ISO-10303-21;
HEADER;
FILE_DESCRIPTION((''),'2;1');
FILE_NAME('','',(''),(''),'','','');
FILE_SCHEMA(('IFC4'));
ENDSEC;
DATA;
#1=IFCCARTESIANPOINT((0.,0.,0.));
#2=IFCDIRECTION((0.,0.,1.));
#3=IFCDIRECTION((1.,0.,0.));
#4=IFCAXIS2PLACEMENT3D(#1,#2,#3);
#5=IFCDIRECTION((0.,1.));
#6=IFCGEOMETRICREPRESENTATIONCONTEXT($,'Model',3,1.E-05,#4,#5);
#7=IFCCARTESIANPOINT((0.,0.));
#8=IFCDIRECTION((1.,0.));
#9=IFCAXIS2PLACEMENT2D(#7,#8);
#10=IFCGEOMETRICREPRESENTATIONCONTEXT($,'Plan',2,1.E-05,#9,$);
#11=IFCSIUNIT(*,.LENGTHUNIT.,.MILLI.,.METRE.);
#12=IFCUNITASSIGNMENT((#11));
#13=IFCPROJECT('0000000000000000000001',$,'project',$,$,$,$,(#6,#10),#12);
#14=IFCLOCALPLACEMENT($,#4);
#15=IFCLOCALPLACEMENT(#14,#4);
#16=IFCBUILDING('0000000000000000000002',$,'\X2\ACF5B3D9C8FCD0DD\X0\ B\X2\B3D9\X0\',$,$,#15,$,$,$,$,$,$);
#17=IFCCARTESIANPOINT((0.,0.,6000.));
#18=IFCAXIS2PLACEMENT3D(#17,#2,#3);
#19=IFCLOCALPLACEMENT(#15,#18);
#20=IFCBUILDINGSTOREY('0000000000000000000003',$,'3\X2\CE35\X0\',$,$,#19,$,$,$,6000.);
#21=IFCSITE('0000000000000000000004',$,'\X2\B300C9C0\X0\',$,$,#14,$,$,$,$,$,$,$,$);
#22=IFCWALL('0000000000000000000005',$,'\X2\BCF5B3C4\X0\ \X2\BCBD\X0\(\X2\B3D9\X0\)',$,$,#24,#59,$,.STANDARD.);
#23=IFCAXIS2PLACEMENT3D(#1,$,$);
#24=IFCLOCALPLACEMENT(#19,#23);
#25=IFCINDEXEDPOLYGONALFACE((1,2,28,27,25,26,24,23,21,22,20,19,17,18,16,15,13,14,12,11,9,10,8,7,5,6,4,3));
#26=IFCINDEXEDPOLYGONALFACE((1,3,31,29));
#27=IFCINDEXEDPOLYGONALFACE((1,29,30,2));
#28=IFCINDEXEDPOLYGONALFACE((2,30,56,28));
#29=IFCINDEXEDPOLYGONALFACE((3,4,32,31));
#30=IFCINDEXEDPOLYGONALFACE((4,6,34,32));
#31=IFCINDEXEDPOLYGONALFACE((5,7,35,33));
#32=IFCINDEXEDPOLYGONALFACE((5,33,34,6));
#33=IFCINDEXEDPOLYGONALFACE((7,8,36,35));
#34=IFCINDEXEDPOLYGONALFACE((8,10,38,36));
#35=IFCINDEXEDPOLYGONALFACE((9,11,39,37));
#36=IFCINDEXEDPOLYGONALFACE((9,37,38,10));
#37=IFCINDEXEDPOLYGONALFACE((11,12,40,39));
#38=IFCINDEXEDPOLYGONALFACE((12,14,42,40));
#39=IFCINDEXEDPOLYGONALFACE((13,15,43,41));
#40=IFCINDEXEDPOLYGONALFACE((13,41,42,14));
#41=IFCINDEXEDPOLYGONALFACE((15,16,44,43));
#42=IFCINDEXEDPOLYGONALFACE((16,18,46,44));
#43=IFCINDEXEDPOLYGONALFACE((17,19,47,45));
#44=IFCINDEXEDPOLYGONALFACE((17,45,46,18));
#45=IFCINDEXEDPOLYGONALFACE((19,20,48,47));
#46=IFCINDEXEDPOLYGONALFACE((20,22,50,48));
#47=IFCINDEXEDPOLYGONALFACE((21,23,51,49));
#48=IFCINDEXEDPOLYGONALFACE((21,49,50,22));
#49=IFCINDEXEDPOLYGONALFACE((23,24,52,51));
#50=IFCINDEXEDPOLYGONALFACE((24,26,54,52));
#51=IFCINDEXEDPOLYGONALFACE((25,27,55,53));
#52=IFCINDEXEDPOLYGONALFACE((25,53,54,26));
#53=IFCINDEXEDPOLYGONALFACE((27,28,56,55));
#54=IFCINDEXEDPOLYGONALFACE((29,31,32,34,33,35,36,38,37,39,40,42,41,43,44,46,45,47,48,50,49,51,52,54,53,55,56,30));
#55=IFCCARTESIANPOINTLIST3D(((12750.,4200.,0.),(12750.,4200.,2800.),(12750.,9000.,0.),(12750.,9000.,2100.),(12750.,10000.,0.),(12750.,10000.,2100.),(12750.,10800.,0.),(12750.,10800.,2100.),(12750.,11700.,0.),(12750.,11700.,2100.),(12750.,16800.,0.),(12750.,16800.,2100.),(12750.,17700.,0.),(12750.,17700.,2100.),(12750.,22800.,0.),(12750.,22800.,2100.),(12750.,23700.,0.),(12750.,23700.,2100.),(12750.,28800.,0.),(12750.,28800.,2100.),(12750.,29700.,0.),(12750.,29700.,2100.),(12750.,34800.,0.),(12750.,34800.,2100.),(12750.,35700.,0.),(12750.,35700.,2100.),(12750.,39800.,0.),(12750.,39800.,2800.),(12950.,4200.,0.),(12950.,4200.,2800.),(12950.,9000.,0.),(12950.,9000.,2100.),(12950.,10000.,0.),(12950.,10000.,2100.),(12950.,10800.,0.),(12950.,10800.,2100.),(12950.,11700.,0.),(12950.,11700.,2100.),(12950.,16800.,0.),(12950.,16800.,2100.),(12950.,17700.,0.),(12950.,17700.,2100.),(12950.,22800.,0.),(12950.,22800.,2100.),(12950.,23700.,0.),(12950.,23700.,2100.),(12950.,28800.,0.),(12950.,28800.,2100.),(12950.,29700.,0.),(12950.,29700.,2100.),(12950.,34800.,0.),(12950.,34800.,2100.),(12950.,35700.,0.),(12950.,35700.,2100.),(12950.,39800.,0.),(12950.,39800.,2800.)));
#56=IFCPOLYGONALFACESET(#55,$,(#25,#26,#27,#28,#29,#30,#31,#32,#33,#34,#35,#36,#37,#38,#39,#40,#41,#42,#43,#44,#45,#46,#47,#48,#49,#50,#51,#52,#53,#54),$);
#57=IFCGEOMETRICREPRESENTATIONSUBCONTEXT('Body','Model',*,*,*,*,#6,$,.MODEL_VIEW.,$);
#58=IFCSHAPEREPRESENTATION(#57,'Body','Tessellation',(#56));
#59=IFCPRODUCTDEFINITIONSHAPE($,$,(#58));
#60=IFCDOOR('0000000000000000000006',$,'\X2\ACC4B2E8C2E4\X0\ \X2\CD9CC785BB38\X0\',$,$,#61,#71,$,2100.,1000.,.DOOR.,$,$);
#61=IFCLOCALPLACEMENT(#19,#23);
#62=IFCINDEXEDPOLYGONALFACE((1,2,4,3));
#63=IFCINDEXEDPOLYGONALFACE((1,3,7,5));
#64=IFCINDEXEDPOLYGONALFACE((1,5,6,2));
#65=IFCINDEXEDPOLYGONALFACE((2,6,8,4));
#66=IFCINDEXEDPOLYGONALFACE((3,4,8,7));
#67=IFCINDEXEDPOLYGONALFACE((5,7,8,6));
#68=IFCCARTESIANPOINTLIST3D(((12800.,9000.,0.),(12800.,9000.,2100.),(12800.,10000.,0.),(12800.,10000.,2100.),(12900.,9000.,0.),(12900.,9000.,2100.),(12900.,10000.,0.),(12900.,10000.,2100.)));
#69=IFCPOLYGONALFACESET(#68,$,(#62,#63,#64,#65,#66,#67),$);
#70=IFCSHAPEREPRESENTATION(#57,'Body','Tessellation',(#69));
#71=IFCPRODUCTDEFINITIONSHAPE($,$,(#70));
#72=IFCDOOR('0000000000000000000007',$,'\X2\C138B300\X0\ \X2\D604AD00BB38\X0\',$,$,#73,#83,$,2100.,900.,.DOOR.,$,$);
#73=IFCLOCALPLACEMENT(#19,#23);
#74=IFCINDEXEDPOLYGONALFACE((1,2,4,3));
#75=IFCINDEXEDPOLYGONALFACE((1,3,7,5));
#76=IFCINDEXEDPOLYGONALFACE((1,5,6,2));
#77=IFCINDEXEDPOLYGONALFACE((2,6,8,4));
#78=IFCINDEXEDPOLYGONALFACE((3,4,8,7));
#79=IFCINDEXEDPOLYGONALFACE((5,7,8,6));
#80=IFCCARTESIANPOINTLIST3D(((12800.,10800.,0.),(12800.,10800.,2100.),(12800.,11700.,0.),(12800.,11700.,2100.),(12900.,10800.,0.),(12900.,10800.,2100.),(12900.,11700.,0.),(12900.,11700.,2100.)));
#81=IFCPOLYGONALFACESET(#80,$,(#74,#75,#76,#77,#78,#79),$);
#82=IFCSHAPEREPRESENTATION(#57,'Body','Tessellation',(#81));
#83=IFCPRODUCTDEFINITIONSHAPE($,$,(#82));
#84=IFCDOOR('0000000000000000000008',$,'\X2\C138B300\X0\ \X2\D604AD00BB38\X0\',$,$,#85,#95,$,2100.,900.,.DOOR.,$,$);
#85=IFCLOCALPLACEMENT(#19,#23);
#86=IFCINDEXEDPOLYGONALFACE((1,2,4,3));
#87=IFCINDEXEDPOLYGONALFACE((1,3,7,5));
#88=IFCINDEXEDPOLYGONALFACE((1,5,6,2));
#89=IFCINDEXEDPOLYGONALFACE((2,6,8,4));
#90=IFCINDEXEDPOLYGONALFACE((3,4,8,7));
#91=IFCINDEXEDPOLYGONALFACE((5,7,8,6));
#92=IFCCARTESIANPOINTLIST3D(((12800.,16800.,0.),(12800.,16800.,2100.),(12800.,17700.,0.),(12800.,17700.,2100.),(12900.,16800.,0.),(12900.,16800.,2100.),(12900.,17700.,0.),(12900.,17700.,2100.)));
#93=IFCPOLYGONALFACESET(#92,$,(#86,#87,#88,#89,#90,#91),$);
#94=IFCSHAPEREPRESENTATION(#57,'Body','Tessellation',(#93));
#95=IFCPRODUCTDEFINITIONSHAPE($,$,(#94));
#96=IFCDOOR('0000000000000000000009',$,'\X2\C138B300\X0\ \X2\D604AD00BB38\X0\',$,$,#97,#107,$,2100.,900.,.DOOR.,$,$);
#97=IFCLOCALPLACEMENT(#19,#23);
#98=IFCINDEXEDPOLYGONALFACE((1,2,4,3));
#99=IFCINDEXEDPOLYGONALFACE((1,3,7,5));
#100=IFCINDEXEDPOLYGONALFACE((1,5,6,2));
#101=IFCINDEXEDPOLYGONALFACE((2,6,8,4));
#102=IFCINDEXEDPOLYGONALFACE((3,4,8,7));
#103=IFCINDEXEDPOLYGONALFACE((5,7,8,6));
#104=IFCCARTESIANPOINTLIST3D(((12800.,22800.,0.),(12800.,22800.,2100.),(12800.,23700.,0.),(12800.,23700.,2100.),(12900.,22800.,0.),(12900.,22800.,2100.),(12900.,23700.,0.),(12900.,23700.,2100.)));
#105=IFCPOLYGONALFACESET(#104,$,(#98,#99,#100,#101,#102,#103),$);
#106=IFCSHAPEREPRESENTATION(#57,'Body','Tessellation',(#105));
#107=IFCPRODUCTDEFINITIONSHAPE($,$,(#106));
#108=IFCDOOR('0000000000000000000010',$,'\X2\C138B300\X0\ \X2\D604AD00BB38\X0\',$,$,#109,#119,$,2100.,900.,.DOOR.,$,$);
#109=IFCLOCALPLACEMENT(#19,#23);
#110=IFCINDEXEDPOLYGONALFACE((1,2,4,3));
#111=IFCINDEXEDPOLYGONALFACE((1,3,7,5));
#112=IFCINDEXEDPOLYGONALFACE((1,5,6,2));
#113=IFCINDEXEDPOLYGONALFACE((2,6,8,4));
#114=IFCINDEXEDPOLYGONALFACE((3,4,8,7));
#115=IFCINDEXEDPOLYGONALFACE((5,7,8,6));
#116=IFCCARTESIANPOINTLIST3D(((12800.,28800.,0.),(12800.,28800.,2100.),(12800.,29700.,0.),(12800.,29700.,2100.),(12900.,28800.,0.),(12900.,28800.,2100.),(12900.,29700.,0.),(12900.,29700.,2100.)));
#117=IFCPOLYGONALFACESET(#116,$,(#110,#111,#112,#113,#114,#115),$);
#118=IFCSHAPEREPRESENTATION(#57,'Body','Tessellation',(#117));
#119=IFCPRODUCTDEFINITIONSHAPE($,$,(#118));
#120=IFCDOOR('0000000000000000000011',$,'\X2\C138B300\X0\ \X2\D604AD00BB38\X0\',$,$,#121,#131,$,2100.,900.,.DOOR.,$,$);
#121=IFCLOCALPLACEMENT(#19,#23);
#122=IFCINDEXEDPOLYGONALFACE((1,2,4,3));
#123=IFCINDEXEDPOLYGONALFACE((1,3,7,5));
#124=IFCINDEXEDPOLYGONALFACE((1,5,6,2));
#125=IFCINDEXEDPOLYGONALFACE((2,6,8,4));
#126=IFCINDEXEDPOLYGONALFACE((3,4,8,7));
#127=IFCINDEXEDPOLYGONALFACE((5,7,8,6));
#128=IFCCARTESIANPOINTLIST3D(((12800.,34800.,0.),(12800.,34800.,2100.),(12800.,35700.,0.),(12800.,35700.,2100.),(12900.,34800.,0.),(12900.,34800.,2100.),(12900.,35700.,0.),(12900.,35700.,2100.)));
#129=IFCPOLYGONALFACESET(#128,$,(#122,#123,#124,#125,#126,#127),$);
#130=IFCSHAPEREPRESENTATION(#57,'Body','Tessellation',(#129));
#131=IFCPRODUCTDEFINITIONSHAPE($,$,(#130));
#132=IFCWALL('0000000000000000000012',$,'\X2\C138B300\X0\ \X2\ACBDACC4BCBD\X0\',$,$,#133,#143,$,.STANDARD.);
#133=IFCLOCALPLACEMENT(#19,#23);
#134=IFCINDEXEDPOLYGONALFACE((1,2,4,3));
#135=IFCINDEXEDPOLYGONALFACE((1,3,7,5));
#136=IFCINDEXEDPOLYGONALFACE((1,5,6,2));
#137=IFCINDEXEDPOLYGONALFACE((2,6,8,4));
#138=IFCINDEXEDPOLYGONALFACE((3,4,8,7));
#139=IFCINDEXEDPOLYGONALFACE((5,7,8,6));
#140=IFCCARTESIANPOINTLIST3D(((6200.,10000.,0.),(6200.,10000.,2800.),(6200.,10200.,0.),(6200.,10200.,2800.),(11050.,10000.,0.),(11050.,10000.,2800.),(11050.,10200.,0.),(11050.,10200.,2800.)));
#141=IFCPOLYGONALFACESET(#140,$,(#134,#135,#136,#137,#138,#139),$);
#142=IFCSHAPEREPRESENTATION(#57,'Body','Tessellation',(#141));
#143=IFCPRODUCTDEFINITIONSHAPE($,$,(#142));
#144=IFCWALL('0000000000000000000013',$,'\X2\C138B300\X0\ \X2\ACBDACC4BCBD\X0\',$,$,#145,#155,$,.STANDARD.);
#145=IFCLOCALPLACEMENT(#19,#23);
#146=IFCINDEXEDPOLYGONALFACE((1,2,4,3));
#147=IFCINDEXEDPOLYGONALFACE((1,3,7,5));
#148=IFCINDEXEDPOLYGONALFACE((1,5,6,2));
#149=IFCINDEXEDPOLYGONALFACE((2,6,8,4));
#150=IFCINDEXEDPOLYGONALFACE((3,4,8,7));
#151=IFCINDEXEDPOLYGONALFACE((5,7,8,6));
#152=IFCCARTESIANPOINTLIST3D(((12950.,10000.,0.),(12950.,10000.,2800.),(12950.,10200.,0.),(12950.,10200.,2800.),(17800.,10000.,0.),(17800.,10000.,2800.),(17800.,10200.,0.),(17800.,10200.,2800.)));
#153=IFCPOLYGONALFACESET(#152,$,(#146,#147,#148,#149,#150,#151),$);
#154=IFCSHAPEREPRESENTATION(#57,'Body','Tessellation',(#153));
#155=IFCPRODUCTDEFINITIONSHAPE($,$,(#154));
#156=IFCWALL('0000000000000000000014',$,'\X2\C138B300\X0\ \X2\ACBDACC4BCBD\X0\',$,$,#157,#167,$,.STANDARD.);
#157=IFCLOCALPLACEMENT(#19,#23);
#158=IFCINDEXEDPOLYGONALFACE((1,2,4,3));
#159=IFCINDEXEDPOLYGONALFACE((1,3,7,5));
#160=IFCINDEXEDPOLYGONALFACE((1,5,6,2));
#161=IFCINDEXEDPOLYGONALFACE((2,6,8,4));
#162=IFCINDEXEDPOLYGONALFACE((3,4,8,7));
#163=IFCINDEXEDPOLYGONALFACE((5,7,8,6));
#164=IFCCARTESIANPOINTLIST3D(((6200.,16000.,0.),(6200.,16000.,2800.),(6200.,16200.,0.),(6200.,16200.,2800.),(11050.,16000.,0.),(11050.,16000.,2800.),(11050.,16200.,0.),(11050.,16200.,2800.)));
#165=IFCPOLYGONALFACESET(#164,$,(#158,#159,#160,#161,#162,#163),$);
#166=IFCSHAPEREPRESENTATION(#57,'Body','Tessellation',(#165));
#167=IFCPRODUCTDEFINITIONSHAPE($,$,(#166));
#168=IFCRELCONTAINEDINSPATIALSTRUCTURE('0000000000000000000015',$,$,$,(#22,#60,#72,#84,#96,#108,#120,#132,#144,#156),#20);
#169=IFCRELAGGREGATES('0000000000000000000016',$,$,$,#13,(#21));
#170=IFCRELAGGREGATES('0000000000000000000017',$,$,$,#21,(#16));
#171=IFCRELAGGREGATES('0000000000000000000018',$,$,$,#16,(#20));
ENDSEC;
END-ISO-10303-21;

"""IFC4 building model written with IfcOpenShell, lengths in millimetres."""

from ifc_helpers import new_model, si_unit, direction, frame, origin_with_axes, origin_2d_with_axis, place, context, subcontext, project, spatial, polyline, outline, extrude, element, fill, save


model = new_model("IFC4")

# Units and contexts
model_context = context("Model", 3, precision=1e-05, world=origin_with_axes(), true_north=direction((0.0, 1.0)))
plan_context = context("Plan", 2, precision=1e-05, world=origin_2d_with_axis())
body_context = subcontext(model_context, "Body", "Model", "MODEL_VIEW")
ifc_project = project(units=[si_unit("LENGTHUNIT", "METRE", prefix="MILLI")], contexts=[model_context, plan_context])

# Site, building, storey
site_placement = place(None, origin_with_axes())
site = spatial("IfcSite", under=ifc_project, at=site_placement, Name="대지")
building_placement = place(site_placement, origin_with_axes())
building = spatial("IfcBuilding", under=site, at=building_placement, Name="공동주택 B동")
storey_placement = place(building_placement, frame((0.0, 0.0, 6000.0), z_axis=(0.0, 0.0, 1.0), x_axis=(1.0, 0.0, 0.0)))
storey = spatial("IfcBuildingStorey", under=building, at=storey_placement, Name="3층", Elevation=6000.0)

# Wall, openings, doors
wall_1_placement = place(storey_placement, origin_with_axes())
wall_1 = element("IfcWall", 1, at=wall_1_placement, inside=storey, Name="복도 벽(동)", PredefinedType="STANDARD", context=body_context, shape_type="SweptSolid", body=[
    extrude(outline(polyline([(12750.0, 4200.0), (12750.0, 39800.0), (12950.0, 39800.0), (12950.0, 4200.0), (12750.0, 4200.0)])), origin_with_axes(), (0.0, 0.0, 1.0), 2800.0),
])
opening_1_placement = place(storey_placement, origin_with_axes())
opening_1 = element("IfcOpeningElement", 2, at=opening_1_placement, cuts=wall_1, PredefinedType="OPENING", context=body_context, shape_type="SweptSolid", body=[
    extrude(outline(polyline([(13000.0, 9000.0), (13000.0, 10000.0), (12700.0, 10000.0), (12700.0, 9000.0), (13000.0, 9000.0)])), origin_with_axes(), (0.0, 0.0, 1.0), 2100.0),
])
opening_2_placement = place(storey_placement, origin_with_axes())
opening_2 = element("IfcOpeningElement", 3, at=opening_2_placement, cuts=wall_1, PredefinedType="OPENING", context=body_context, shape_type="SweptSolid", body=[
    extrude(outline(polyline([(13000.0, 10800.0), (13000.0, 11700.0), (12700.0, 11700.0), (12700.0, 10800.0), (13000.0, 10800.0)])), origin_with_axes(), (0.0, 0.0, 1.0), 2100.0),
])
opening_3_placement = place(storey_placement, origin_with_axes())
opening_3 = element("IfcOpeningElement", 4, at=opening_3_placement, cuts=wall_1, PredefinedType="OPENING", context=body_context, shape_type="SweptSolid", body=[
    extrude(outline(polyline([(13000.0, 16800.0), (13000.0, 17700.0), (12700.0, 17700.0), (12700.0, 16800.0), (13000.0, 16800.0)])), origin_with_axes(), (0.0, 0.0, 1.0), 2100.0),
])
opening_4_placement = place(storey_placement, origin_with_axes())
opening_4 = element("IfcOpeningElement", 5, at=opening_4_placement, cuts=wall_1, PredefinedType="OPENING", context=body_context, shape_type="SweptSolid", body=[
    extrude(outline(polyline([(13000.0, 22800.0), (13000.0, 23700.0), (12700.0, 23700.0), (12700.0, 22800.0), (13000.0, 22800.0)])), origin_with_axes(), (0.0, 0.0, 1.0), 2100.0),
])
opening_5_placement = place(storey_placement, origin_with_axes())
opening_5 = element("IfcOpeningElement", 6, at=opening_5_placement, cuts=wall_1, PredefinedType="OPENING", context=body_context, shape_type="SweptSolid", body=[
    extrude(outline(polyline([(13000.0, 28800.0), (13000.0, 29700.0), (12700.0, 29700.0), (12700.0, 28800.0), (13000.0, 28800.0)])), origin_with_axes(), (0.0, 0.0, 1.0), 2100.0),
])
opening_6_placement = place(storey_placement, origin_with_axes())
opening_6 = element("IfcOpeningElement", 7, at=opening_6_placement, cuts=wall_1, PredefinedType="OPENING", context=body_context, shape_type="SweptSolid", body=[
    extrude(outline(polyline([(13000.0, 34800.0), (13000.0, 35700.0), (12700.0, 35700.0), (12700.0, 34800.0), (13000.0, 34800.0)])), origin_with_axes(), (0.0, 0.0, 1.0), 2100.0),
])
door_1_placement = place(storey_placement, origin_with_axes())
door_1 = element("IfcDoor", 8, at=door_1_placement, inside=storey, Name="계단실 출입문", OverallHeight=2100.0, OverallWidth=1000.0, PredefinedType="DOOR", context=body_context, shape_type="SweptSolid", body=[
    extrude(outline(polyline([(12900.0, 9000.0), (12900.0, 10000.0), (12800.0, 10000.0), (12800.0, 9000.0), (12900.0, 9000.0)])), origin_with_axes(), (0.0, 0.0, 1.0), 2100.0),
])
fill(opening_1, door_1)
door_2_placement = place(storey_placement, origin_with_axes())
door_2 = element("IfcDoor", 9, at=door_2_placement, inside=storey, Name="세대 현관문", OverallHeight=2100.0, OverallWidth=900.0, PredefinedType="DOOR", context=body_context, shape_type="SweptSolid", body=[
    extrude(outline(polyline([(12900.0, 10800.0), (12900.0, 11700.0), (12800.0, 11700.0), (12800.0, 10800.0), (12900.0, 10800.0)])), origin_with_axes(), (0.0, 0.0, 1.0), 2100.0),
])
fill(opening_2, door_2)
door_3_placement = place(storey_placement, origin_with_axes())
door_3 = element("IfcDoor", 10, at=door_3_placement, inside=storey, Name="세대 현관문", OverallHeight=2100.0, OverallWidth=900.0, PredefinedType="DOOR", context=body_context, shape_type="SweptSolid", body=[
    extrude(outline(polyline([(12900.0, 16800.0), (12900.0, 17700.0), (12800.0, 17700.0), (12800.0, 16800.0), (12900.0, 16800.0)])), origin_with_axes(), (0.0, 0.0, 1.0), 2100.0),
])
fill(opening_3, door_3)
door_4_placement = place(storey_placement, origin_with_axes())
door_4 = element("IfcDoor", 11, at=door_4_placement, inside=storey, Name="세대 현관문", OverallHeight=2100.0, OverallWidth=900.0, PredefinedType="DOOR", context=body_context, shape_type="SweptSolid", body=[
    extrude(outline(polyline([(12900.0, 22800.0), (12900.0, 23700.0), (12800.0, 23700.0), (12800.0, 22800.0), (12900.0, 22800.0)])), origin_with_axes(), (0.0, 0.0, 1.0), 2100.0),
])
fill(opening_4, door_4)
door_5_placement = place(storey_placement, origin_with_axes())
door_5 = element("IfcDoor", 12, at=door_5_placement, inside=storey, Name="세대 현관문", OverallHeight=2100.0, OverallWidth=900.0, PredefinedType="DOOR", context=body_context, shape_type="SweptSolid", body=[
    extrude(outline(polyline([(12900.0, 28800.0), (12900.0, 29700.0), (12800.0, 29700.0), (12800.0, 28800.0), (12900.0, 28800.0)])), origin_with_axes(), (0.0, 0.0, 1.0), 2100.0),
])
fill(opening_5, door_5)
door_6_placement = place(storey_placement, origin_with_axes())
door_6 = element("IfcDoor", 13, at=door_6_placement, inside=storey, Name="세대 현관문", OverallHeight=2100.0, OverallWidth=900.0, PredefinedType="DOOR", context=body_context, shape_type="SweptSolid", body=[
    extrude(outline(polyline([(12900.0, 34800.0), (12900.0, 35700.0), (12800.0, 35700.0), (12800.0, 34800.0), (12900.0, 34800.0)])), origin_with_axes(), (0.0, 0.0, 1.0), 2100.0),
])
fill(opening_6, door_6)

# Walls
wall_2_placement = place(storey_placement, origin_with_axes())
element("IfcWall", 14, at=wall_2_placement, inside=storey, Name="세대 경계벽", PredefinedType="STANDARD", context=body_context, shape_type="SweptSolid", body=[
    extrude(outline(polyline([(6200.0, 10200.0), (11050.0, 10200.0), (11050.0, 10000.0), (6200.0, 10000.0), (6200.0, 10200.0)])), origin_with_axes(), (0.0, 0.0, 1.0), 2800.0),
])
wall_3_placement = place(storey_placement, origin_with_axes())
element("IfcWall", 15, at=wall_3_placement, inside=storey, Name="세대 경계벽", PredefinedType="STANDARD", context=body_context, shape_type="SweptSolid", body=[
    extrude(outline(polyline([(12950.0, 10200.0), (17800.0, 10200.0), (17800.0, 10000.0), (12950.0, 10000.0), (12950.0, 10200.0)])), origin_with_axes(), (0.0, 0.0, 1.0), 2800.0),
])
wall_4_placement = place(storey_placement, origin_with_axes())
element("IfcWall", 16, at=wall_4_placement, inside=storey, Name="세대 경계벽", PredefinedType="STANDARD", context=body_context, shape_type="SweptSolid", body=[
    extrude(outline(polyline([(6200.0, 16200.0), (11050.0, 16200.0), (11050.0, 16000.0), (6200.0, 16000.0), (6200.0, 16200.0)])), origin_with_axes(), (0.0, 0.0, 1.0), 2800.0),
])

save(model, "model.ifc")
